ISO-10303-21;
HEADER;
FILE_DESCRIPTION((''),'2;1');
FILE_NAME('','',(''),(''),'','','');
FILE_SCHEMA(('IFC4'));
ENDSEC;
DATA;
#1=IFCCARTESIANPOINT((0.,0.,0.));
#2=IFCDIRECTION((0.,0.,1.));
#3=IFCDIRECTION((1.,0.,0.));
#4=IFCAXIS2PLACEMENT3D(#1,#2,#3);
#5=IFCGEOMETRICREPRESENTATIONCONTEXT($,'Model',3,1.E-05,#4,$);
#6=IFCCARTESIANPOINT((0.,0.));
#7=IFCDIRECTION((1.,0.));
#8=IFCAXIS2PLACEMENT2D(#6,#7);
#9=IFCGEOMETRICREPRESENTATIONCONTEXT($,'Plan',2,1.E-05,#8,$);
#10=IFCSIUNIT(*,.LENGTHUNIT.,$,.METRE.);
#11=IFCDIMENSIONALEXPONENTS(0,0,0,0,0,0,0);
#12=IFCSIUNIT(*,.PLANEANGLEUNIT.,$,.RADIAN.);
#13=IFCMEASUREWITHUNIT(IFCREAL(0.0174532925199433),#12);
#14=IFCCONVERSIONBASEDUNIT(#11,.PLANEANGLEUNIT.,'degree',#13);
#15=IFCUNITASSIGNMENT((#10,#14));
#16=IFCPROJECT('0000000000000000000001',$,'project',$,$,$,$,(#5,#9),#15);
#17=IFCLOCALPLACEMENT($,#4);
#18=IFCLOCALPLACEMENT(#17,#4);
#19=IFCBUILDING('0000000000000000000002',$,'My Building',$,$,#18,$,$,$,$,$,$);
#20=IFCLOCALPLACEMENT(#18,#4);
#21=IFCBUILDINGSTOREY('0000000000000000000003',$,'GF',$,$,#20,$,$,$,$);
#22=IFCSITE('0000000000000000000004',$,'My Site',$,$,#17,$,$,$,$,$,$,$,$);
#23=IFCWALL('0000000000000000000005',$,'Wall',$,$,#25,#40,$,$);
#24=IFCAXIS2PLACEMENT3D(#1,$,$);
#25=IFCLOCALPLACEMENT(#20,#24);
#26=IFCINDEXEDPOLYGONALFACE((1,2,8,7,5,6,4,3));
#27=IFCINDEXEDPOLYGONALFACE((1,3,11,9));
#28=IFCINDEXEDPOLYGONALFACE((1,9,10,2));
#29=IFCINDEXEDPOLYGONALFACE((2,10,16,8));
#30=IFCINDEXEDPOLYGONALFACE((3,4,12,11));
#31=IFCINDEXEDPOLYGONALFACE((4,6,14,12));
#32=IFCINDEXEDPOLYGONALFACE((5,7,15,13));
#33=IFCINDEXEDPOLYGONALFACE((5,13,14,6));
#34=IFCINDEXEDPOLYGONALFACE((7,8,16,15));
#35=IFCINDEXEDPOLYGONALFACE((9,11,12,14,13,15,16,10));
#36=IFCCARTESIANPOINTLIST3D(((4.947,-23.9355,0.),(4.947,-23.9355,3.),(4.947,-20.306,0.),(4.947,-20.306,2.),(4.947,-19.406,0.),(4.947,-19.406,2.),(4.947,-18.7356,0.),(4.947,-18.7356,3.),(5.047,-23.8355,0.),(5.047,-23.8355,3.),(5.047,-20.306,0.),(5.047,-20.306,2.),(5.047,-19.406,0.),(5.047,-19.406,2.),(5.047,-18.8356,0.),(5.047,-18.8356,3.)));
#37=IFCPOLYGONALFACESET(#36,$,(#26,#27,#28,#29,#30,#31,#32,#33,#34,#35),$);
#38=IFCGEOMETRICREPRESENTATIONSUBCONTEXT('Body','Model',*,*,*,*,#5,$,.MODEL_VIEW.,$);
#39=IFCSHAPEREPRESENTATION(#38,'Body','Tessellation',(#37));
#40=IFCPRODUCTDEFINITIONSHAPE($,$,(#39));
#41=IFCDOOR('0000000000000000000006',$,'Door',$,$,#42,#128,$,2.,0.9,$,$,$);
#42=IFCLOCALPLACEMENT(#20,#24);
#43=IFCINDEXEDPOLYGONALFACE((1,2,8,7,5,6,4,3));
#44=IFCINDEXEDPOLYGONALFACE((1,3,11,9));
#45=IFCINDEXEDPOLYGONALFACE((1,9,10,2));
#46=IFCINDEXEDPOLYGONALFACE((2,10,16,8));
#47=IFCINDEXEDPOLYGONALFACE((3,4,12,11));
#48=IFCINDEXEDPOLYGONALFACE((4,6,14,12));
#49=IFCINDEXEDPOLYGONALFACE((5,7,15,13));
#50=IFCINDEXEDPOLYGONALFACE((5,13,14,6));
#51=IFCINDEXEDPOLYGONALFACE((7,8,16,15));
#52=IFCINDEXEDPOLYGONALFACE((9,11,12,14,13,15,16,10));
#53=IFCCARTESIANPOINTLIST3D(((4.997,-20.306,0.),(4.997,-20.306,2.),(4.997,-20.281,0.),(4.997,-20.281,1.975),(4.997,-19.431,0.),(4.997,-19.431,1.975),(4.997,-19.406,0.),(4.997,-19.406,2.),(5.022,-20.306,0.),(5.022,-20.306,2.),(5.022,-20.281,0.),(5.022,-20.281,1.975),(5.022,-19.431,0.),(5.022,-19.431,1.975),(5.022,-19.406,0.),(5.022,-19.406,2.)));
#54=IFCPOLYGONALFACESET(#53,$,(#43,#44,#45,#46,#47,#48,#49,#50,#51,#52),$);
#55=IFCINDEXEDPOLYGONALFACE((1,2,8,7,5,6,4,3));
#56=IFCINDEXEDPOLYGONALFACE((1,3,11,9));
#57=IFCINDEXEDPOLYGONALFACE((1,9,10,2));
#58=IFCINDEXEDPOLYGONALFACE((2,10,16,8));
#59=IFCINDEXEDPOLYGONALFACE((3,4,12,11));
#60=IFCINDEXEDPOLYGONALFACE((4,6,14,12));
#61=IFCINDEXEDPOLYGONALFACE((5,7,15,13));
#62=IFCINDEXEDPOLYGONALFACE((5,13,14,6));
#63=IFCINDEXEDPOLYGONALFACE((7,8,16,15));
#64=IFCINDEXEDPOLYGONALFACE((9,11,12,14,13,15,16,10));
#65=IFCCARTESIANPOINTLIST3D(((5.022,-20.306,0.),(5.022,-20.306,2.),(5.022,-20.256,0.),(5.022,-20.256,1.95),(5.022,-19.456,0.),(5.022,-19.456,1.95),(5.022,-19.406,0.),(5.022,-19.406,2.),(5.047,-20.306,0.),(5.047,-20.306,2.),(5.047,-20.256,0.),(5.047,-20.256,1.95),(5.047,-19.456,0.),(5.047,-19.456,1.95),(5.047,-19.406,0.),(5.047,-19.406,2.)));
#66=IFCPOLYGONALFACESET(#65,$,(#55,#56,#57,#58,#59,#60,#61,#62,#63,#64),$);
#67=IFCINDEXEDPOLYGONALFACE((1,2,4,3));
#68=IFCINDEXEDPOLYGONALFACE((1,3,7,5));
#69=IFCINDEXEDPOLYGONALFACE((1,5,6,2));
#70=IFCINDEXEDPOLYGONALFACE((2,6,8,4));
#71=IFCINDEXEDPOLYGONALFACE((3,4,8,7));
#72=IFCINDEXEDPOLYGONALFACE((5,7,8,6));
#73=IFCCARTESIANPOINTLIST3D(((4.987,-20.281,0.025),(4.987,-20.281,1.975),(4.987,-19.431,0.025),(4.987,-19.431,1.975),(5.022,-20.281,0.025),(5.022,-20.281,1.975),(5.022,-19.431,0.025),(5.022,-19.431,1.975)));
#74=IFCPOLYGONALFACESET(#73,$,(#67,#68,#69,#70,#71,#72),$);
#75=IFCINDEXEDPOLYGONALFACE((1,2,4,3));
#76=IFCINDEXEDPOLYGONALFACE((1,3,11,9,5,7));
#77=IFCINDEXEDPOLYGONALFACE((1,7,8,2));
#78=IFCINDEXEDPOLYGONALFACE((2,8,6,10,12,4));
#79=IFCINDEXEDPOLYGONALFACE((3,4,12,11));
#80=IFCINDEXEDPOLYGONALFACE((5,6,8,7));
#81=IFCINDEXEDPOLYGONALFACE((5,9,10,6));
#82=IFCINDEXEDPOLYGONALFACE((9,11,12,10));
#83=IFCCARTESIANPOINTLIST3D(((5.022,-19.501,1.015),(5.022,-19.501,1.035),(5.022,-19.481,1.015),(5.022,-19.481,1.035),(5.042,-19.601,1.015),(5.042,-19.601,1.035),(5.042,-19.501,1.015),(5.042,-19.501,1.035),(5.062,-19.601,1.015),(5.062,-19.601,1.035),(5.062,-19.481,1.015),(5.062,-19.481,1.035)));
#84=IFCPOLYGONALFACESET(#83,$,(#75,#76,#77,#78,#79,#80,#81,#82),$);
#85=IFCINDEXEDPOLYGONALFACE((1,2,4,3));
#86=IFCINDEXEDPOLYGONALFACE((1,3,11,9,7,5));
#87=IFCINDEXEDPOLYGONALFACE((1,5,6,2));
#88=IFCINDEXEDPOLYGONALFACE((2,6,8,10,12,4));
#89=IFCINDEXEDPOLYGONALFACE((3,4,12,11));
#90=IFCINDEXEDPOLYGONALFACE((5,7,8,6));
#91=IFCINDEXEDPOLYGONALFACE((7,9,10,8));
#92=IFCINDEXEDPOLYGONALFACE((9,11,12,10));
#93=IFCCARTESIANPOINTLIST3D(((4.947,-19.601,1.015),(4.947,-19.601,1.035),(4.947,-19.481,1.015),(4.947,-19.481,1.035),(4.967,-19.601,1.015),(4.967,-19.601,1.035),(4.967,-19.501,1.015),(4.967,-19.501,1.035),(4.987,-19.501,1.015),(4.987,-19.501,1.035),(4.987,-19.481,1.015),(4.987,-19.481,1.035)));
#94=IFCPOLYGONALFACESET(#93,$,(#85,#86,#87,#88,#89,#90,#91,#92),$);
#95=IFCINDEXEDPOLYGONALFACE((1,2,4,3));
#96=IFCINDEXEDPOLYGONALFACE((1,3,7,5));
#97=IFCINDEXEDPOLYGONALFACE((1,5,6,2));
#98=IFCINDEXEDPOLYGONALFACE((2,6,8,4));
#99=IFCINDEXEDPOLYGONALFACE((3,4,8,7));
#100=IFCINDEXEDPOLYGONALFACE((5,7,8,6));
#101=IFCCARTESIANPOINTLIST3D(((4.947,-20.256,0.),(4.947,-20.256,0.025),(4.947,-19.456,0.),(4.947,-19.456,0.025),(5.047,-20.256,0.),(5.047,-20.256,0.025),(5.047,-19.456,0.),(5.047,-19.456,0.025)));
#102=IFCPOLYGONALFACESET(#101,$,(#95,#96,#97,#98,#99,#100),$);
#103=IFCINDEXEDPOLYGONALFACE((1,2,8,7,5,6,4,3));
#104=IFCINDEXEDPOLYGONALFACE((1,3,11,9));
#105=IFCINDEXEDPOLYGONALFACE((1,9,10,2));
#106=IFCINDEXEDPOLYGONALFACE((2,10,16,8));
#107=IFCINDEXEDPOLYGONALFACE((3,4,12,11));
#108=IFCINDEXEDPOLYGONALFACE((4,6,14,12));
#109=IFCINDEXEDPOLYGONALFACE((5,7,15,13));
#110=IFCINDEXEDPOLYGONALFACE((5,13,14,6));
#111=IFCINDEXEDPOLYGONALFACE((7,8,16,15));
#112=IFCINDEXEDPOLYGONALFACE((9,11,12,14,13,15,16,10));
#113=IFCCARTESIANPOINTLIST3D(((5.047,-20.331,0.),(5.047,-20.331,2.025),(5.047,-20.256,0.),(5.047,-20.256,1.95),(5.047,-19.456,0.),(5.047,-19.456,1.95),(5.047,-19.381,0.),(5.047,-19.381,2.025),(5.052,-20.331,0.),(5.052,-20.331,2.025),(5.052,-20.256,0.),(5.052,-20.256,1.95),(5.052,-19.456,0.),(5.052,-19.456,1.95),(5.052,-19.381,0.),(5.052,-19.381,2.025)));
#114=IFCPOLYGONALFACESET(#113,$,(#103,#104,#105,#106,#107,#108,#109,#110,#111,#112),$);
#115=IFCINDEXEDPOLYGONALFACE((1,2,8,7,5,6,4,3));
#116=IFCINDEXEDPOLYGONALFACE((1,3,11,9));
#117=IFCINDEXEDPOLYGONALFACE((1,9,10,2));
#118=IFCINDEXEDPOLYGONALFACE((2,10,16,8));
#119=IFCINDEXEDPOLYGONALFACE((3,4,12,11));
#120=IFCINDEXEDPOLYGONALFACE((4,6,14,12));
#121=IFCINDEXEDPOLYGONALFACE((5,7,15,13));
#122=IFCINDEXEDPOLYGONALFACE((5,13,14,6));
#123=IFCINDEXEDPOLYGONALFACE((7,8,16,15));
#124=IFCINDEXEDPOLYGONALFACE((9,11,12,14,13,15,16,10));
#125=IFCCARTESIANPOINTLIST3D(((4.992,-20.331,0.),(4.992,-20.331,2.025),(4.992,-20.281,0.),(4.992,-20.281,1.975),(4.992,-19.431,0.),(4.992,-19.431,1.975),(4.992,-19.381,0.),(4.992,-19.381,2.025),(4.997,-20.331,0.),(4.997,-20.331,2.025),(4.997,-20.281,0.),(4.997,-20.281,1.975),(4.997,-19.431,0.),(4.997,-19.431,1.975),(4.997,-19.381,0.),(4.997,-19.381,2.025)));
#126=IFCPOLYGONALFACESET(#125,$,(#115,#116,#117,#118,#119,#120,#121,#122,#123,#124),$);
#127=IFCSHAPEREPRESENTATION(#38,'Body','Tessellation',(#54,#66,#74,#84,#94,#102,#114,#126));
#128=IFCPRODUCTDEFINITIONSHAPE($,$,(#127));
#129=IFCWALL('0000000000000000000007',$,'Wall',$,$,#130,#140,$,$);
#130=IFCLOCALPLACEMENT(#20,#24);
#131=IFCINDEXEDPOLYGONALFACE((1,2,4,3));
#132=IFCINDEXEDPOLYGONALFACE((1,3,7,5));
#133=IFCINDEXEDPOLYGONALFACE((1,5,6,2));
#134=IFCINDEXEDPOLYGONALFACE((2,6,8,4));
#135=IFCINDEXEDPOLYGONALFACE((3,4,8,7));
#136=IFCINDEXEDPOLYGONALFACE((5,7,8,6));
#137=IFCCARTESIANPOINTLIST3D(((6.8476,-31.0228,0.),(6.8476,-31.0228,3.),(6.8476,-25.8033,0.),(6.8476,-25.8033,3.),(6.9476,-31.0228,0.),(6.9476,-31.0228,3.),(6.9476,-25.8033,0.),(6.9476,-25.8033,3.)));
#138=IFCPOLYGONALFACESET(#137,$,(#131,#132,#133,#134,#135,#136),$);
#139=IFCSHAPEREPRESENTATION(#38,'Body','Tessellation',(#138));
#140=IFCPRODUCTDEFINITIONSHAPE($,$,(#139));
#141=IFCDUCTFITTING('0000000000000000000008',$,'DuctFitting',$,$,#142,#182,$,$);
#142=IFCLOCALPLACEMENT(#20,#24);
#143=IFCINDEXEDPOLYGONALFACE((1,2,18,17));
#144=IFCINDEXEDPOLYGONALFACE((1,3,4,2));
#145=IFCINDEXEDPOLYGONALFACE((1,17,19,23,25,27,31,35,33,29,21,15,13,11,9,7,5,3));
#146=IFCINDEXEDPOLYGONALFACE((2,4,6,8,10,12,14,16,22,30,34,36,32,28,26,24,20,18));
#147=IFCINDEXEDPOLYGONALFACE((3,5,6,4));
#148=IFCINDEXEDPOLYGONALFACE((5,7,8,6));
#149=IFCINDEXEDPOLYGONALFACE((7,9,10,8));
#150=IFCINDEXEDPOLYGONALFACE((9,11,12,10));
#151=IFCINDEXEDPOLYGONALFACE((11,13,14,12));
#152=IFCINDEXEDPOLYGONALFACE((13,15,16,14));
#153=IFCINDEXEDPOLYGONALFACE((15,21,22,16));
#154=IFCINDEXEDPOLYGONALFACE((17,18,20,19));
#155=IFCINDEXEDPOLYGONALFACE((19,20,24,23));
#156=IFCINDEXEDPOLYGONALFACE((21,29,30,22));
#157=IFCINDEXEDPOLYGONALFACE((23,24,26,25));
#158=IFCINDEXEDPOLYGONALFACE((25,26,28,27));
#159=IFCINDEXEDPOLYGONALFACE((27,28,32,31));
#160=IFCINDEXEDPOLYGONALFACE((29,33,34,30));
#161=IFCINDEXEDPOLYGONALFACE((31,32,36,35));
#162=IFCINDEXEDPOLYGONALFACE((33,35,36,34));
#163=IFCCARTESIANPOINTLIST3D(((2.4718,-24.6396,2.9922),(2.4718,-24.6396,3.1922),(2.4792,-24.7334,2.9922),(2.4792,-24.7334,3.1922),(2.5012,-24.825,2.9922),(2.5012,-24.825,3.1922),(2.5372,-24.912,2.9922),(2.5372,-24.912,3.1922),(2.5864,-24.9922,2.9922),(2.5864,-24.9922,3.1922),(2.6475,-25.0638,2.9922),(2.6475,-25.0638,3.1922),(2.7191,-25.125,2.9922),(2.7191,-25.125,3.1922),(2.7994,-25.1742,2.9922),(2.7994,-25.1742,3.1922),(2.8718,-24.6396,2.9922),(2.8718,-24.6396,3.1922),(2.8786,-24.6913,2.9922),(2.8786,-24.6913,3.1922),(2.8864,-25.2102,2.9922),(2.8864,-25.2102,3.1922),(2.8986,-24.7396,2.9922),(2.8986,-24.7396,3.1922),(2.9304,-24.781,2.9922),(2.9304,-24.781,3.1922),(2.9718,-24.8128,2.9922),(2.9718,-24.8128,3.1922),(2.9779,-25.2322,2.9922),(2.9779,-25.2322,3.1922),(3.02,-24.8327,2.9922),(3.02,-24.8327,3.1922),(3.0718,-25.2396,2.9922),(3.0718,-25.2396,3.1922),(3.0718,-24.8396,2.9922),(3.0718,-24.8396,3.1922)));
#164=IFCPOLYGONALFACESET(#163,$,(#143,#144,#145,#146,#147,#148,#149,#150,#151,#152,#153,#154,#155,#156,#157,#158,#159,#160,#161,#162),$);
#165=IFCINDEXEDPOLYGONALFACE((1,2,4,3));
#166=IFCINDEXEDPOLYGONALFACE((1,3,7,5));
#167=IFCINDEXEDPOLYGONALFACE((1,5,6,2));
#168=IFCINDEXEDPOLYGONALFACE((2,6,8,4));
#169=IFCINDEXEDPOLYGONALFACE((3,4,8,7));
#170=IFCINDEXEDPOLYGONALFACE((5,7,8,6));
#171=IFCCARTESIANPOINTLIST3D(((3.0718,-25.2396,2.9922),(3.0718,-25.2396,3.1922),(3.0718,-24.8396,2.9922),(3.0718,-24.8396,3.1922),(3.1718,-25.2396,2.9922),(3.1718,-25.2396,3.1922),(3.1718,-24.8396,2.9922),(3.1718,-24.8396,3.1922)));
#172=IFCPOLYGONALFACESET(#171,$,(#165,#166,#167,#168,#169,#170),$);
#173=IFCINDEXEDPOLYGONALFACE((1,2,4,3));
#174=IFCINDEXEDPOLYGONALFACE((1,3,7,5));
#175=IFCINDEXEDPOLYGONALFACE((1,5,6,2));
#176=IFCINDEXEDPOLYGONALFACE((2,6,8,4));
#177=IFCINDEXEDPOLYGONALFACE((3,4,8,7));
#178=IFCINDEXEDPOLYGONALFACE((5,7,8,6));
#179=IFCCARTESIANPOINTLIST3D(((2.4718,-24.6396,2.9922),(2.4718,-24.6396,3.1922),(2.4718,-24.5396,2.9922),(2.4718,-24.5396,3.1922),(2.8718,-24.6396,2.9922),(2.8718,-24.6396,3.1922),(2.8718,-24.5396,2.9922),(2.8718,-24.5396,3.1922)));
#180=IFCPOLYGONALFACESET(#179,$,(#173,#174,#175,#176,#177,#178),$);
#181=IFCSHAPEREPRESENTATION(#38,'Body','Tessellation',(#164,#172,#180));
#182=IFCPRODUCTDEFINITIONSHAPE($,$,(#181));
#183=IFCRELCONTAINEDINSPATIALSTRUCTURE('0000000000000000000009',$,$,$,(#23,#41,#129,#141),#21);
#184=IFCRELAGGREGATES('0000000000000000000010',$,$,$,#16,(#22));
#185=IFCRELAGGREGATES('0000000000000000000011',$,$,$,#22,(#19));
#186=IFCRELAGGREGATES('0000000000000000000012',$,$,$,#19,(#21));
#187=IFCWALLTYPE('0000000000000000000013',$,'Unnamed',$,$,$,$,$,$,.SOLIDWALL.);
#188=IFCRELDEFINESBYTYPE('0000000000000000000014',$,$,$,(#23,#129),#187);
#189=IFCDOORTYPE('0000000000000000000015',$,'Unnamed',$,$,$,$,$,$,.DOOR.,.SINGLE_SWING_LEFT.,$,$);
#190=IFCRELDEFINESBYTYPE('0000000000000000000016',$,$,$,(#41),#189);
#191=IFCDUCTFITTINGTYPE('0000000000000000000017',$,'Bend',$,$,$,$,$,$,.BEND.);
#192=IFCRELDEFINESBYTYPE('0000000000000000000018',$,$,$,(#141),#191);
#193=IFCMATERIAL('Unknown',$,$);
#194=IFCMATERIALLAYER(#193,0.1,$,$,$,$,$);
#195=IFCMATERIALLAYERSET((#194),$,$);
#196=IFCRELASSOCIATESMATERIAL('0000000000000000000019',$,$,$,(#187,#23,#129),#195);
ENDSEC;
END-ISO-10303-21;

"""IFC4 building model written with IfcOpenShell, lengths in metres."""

from ifc_helpers import new_model, entity, si_unit, converted_unit, frame, origin_with_axes, origin_2d_with_axis, place, context, subcontext, project, spatial, line, arc, indexed_curve, rectangle, outline, extrude, shape, source, transform, mapped, material, layer, layer_set, layer_usage, type_object, type_shapes, element, fill, save


model = new_model("IFC4")

# Units and contexts
model_context = context("Model", 3, precision=1e-05, world=origin_with_axes())
plan_context = context("Plan", 2, precision=1e-05, world=origin_2d_with_axis())
body_context_1 = subcontext(model_context, "Body", "Model", "MODEL_VIEW")
body_context_2 = subcontext(plan_context, "Body", "Plan", "PLAN_VIEW")
ifc_project = project(units=[si_unit("LENGTHUNIT", "METRE"), converted_unit("PLANEANGLEUNIT", "degree", entity("IfcReal", 0.0174532925199433), si_unit("PLANEANGLEUNIT", "RADIAN"), dimensions=[0, 0, 0, 0, 0, 0, 0])], contexts=[model_context, plan_context])

# Site, building, storey
site_placement = place(None, origin_with_axes())
site = spatial("IfcSite", under=ifc_project, at=site_placement, Name="My Site")
building_placement = place(site_placement, origin_with_axes())
building = spatial("IfcBuilding", under=site, at=building_placement, Name="My Building")
storey_placement = place(building_placement, origin_with_axes())
storey = spatial("IfcBuildingStorey", under=building, at=storey_placement, Name="GF")

# Shared definitions
ifc_material = material(Name="Unknown")
ifc_layer = layer(ifc_material, 0.1)
ifc_layer_set = layer_set([ifc_layer])
wall_type = type_object("IfcWallType", Name="Unnamed", PredefinedType="SOLIDWALL", material=ifc_layer_set)

# Shared definitions
shared_shape_1 = source(origin_with_axes(), body_context_1, "Body", "SweptSolid", [
    extrude(outline(indexed_curve([(0.0, 0.0), (0.9, 0.0), (0.9, 2.0), (0.0, 2.0)], segments=[line(1, 2, 3, 4, 1)])), frame((0.0, -0.6, 0.0), z_axis=(0.0, -1.0, 0.0), x_axis=(1.0, 0.0, 0.0)), (0.0, 0.0, -1.0), 1.2),
])
door_type = type_object("IfcDoorType", Name="Unnamed", OperationType="SINGLE_SWING_LEFT", PredefinedType="DOOR")
shared_shape_2 = source(origin_with_axes(), body_context_1, "Body", "SweptSolid", [
    extrude(outline(indexed_curve([(0.0, 0.0), (0.0, 2.0), (0.9, 2.0), (0.9, 0.0), (0.875, 0.0), (0.875, 1.975), (0.025, 1.975), (0.025, 0.0)], segments=[line(1, 2, 3, 4, 5, 6, 7, 8, 1)])), frame((0.0, 0.025, 0.0), z_axis=(0.0, -1.0, 0.0), x_axis=(1.0, 0.0, 0.0)), (0.0, 0.0, -1.0), 0.025),
    extrude(outline(indexed_curve([(0.0, 0.0), (0.0, 2.0), (0.9, 2.0), (0.9, 0.0), (0.85, 0.0), (0.85, 1.95), (0.05, 1.95), (0.05, 0.0)], segments=[line(1, 2, 3, 4, 5, 6, 7, 8, 1)])), frame((0.0, 0.0, 0.0), z_axis=(0.0, -1.0, 0.0), x_axis=(1.0, 0.0, 0.0)), (0.0, 0.0, -1.0), 0.025),
    extrude(outline(indexed_curve([(0.0, 0.0), (0.85, 0.0), (0.85, 0.035), (0.0, 0.035)], segments=[line(1, 2, 3, 4, 1)])), frame((0.025, 0.025, 0.025), z_axis=(0.0, 0.0, 1.0), x_axis=(1.0, 0.0, 0.0)), (0.0, 0.0, 1.0), 1.95),
    extrude(outline(indexed_curve([(0.0, 0.0), (0.0, -0.04), (-0.12, -0.04), (-0.12, -0.02), (-0.02, -0.02), (-0.02, 0.0)], segments=[line(1, 2, 3, 4, 5, 6, 1)])), frame((0.825, 0.025, 1.015), z_axis=(0.0, 0.0, 1.0), x_axis=(1.0, 0.0, 0.0)), (0.0, 0.0, 1.0), 0.02),
    extrude(outline(indexed_curve([(0.0, 0.0), (0.0, 0.04), (-0.12, 0.04), (-0.12, 0.02), (-0.02, 0.02), (-0.02, 0.0)], segments=[line(1, 2, 3, 4, 5, 6, 1)])), frame((0.825, 0.06, 1.015), z_axis=(0.0, 0.0, 1.0), x_axis=(1.0, 0.0, 0.0)), (0.0, 0.0, 1.0), 0.02),
    extrude(outline(indexed_curve([(0.0, 0.0), (0.8, 0.0), (0.8, 0.1), (0.0, 0.1)], segments=[line(1, 2, 3, 4, 1)])), frame((0.05, 0.0, 0.0), z_axis=(0.0, 0.0, 1.0), x_axis=(1.0, 0.0, 0.0)), (0.0, 0.0, 1.0), 0.025),
    extrude(outline(indexed_curve([(0.0, 0.0), (0.0, 2.025), (0.95, 2.025), (0.95, 0.0), (0.875, 0.0), (0.875, 1.95), (0.075, 1.95), (0.075, 0.0)], segments=[line(1, 2, 3, 4, 5, 6, 7, 8, 1)])), frame((-0.025, -0.005, 0.0), z_axis=(0.0, -1.0, 0.0), x_axis=(1.0, 0.0, 0.0)), (0.0, 0.0, -1.0), 0.005),
    extrude(outline(indexed_curve([(0.0, 0.0), (0.0, 2.025), (0.95, 2.025), (0.95, 0.0), (0.9, 0.0), (0.9, 1.975), (0.05, 1.975), (0.05, 0.0)], segments=[line(1, 2, 3, 4, 5, 6, 7, 8, 1)])), frame((-0.025, 0.05, 0.0), z_axis=(0.0, -1.0, 0.0), x_axis=(1.0, 0.0, 0.0)), (0.0, 0.0, -1.0), 0.005),
])
shared_shape_3 = source(origin_with_axes(), body_context_2, "Body", "Curve2D", [
    entity("IfcIndexedPolyCurve", entity("IfcCartesianPointList2D", [[0.0, 0.0], [0.0, 0.05], [0.025, 0.05], [0.025, 0.025], [0.05, 0.025], [0.05, 0.0]]), [entity("IfcLineIndex", [1, 2, 3, 4, 5, 6, 1])]),
    entity("IfcIndexedPolyCurve", entity("IfcCartesianPointList2D", [[0.9, 0.0], [0.9, 0.05], [0.875, 0.05], [0.875, 0.025], [0.85, 0.025], [0.85, 0.0]]), [entity("IfcLineIndex", [1, 2, 3, 4, 5, 6, 1])]),
    entity("IfcTrimmedCurve", entity("IfcEllipse", entity("IfcAxis2Placement2D", entity("IfcCartesianPoint", [0.06, 0.05]), entity("IfcDirection", [1.0, 0.0])), 0.815, 0.85), [entity("IfcCartesianPoint", [0.875, 0.05])], [entity("IfcCartesianPoint", [0.06, 0.9])], True, "CARTESIAN"),
    entity("IfcIndexedPolyCurve", entity("IfcCartesianPointList2D", [[0.025, 0.05], [0.06, 0.05], [0.06, 0.9], [0.025, 0.9]]), [entity("IfcLineIndex", [1, 2, 3, 4, 1])]),
])
type_shapes(door_type, [shared_shape_2, shared_shape_3])

# Wall, opening, door
ifc_layer_usage_1 = layer_usage(ifc_layer_set, "AXIS2", "POSITIVE", 0.0)
wall_1_placement = place(storey_placement, frame((5.047, -23.8355, 0.0), z_axis=(0.0, 0.0, 1.0), x_axis=(0.0, 1.0, 0.0)))
wall_1 = element("IfcWall", 1, at=wall_1_placement, inside=storey, type_object=wall_type, material=ifc_layer_usage_1, Name="Wall", context=body_context_1, shape_type="SweptSolid", body=[
    extrude(outline(indexed_curve([(0.0, 0.0), (-0.1, 0.1), (5.1, 0.1), (5.0, 0.0)], segments=[line(1, 2, 3, 4, 1)])), origin_with_axes(), (0.0, 0.0, 1.0), 3.0),
])
opening_1_placement = place(wall_1_placement, frame((3.5295, 0.0, 0.0), z_axis=(0.0, 0.0, 1.0), x_axis=(1.0, 0.0, 0.0)))
opening_1 = element("IfcOpeningElement", 2, at=opening_1_placement, cuts=wall_1, PredefinedType="OPENING", context=body_context_1, shape_type="MappedRepresentation", body=[
    mapped(shared_shape_1, transform((0.0, 0.0, 0.0), x_axis=(1.0, 0.0, 0.0), y_axis=(0.0, 1.0, 0.0), z_axis=(0.0, 0.0, 1.0), scale=1.0)),
])
door_1_placement = place(opening_1_placement, frame((0.0, 0.0, 0.0), z_axis=(0.0, 0.0, 1.0), x_axis=(1.0, 0.0, 0.0)))
door_1 = element("IfcDoor", 3, at=door_1_placement, inside=storey, type_object=door_type, Name="Door", OverallHeight=2.0, OverallWidth=0.9, shapes=[
    shape(body_context_1, "Body", "MappedRepresentation", [mapped(shared_shape_2, transform((0.0, 0.0, 0.0), x_axis=(1.0, 0.0, 0.0), y_axis=(0.0, 1.0, 0.0), z_axis=(0.0, 0.0, 1.0), scale=1.0))]),
    shape(body_context_2, "Body", "MappedRepresentation", [mapped(shared_shape_3, transform((0.0, 0.0, 0.0), x_axis=(1.0, 0.0, 0.0), y_axis=(0.0, 1.0, 0.0), z_axis=(0.0, 0.0, 1.0), scale=1.0))]),
])
fill(opening_1, door_1)

# Wall
ifc_layer_usage_2 = layer_usage(ifc_layer_set, "AXIS2", "POSITIVE", 0.0)
wall_2_placement = place(storey_placement, frame((6.8476, -25.8033, 0.0), z_axis=(0.0, 0.0, 1.0), x_axis=(0.0, -1.0, 0.0)))
element("IfcWall", 4, at=wall_2_placement, inside=storey, type_object=wall_type, material=ifc_layer_usage_2, Name="Wall", context=body_context_1, shape_type="SweptSolid", body=[
    extrude(outline(indexed_curve([(0.0, 0.0), (0.0, 0.1), (5.2195, 0.1), (5.2195, 0.0)], segments=[line(1, 2, 3, 4, 1)])), origin_with_axes(), (0.0, 0.0, 1.0), 3.0),
])

# Duct fitting
duct_fitting_type = type_object("IfcDuctFittingType", Name="Bend", PredefinedType="BEND")
shared_shape_4 = source(origin_with_axes(), body_context_1, "Body", "SweptSolid", [
    extrude(outline(indexed_curve([(0.2, 0.0), (0.2586, -0.1414), (0.4, -0.2), (0.4, -0.6), (-0.0243, -0.4243), (-0.2, 0.0)], segments=[arc(1, 2, 3), line(3, 4), arc(4, 5, 6), line(6, 1)])), frame((0.0, -0.1, -0.1), z_axis=(0.0, -1.0, 0.0), x_axis=(1.0, 0.0, 0.0)), (0.0, 0.0, -1.0), 0.2),
    extrude(rectangle(XDim=0.4, YDim=0.2), origin_with_axes(), (0.0, 0.0, -1.0), 0.1),
    extrude(rectangle(XDim=0.4, YDim=0.2), frame((0.4, 0.0, -0.5), z_axis=(1.0, 0.0, 0.0), x_axis=(0.0, 0.0, 1.0)), (0.0, 0.0, 1.0), 0.1),
])
type_shapes(duct_fitting_type, [shared_shape_4])
for number, where, z_axis, x_axis, name in (
    (5, (3.1718, -25.0396, 3.0922), (1.0, 0.0, 0.0), (0.0, 1.0, 0.0), "DuctFitting"),
):
    element("IfcDuctFitting", number, at=place(storey_placement, frame(where, z_axis=z_axis, x_axis=x_axis)), inside=storey, type_object=duct_fitting_type, Name=name, context=body_context_1, shape_type="MappedRepresentation", body=[
        mapped(shared_shape_4, transform((0.0, 0.0, 0.0), x_axis=(1.0, 0.0, 0.0), y_axis=(0.0, 1.0, 0.0), z_axis=(0.0, 0.0, 1.0), scale=1.0)),
    ])

save(model, "model.ifc")
